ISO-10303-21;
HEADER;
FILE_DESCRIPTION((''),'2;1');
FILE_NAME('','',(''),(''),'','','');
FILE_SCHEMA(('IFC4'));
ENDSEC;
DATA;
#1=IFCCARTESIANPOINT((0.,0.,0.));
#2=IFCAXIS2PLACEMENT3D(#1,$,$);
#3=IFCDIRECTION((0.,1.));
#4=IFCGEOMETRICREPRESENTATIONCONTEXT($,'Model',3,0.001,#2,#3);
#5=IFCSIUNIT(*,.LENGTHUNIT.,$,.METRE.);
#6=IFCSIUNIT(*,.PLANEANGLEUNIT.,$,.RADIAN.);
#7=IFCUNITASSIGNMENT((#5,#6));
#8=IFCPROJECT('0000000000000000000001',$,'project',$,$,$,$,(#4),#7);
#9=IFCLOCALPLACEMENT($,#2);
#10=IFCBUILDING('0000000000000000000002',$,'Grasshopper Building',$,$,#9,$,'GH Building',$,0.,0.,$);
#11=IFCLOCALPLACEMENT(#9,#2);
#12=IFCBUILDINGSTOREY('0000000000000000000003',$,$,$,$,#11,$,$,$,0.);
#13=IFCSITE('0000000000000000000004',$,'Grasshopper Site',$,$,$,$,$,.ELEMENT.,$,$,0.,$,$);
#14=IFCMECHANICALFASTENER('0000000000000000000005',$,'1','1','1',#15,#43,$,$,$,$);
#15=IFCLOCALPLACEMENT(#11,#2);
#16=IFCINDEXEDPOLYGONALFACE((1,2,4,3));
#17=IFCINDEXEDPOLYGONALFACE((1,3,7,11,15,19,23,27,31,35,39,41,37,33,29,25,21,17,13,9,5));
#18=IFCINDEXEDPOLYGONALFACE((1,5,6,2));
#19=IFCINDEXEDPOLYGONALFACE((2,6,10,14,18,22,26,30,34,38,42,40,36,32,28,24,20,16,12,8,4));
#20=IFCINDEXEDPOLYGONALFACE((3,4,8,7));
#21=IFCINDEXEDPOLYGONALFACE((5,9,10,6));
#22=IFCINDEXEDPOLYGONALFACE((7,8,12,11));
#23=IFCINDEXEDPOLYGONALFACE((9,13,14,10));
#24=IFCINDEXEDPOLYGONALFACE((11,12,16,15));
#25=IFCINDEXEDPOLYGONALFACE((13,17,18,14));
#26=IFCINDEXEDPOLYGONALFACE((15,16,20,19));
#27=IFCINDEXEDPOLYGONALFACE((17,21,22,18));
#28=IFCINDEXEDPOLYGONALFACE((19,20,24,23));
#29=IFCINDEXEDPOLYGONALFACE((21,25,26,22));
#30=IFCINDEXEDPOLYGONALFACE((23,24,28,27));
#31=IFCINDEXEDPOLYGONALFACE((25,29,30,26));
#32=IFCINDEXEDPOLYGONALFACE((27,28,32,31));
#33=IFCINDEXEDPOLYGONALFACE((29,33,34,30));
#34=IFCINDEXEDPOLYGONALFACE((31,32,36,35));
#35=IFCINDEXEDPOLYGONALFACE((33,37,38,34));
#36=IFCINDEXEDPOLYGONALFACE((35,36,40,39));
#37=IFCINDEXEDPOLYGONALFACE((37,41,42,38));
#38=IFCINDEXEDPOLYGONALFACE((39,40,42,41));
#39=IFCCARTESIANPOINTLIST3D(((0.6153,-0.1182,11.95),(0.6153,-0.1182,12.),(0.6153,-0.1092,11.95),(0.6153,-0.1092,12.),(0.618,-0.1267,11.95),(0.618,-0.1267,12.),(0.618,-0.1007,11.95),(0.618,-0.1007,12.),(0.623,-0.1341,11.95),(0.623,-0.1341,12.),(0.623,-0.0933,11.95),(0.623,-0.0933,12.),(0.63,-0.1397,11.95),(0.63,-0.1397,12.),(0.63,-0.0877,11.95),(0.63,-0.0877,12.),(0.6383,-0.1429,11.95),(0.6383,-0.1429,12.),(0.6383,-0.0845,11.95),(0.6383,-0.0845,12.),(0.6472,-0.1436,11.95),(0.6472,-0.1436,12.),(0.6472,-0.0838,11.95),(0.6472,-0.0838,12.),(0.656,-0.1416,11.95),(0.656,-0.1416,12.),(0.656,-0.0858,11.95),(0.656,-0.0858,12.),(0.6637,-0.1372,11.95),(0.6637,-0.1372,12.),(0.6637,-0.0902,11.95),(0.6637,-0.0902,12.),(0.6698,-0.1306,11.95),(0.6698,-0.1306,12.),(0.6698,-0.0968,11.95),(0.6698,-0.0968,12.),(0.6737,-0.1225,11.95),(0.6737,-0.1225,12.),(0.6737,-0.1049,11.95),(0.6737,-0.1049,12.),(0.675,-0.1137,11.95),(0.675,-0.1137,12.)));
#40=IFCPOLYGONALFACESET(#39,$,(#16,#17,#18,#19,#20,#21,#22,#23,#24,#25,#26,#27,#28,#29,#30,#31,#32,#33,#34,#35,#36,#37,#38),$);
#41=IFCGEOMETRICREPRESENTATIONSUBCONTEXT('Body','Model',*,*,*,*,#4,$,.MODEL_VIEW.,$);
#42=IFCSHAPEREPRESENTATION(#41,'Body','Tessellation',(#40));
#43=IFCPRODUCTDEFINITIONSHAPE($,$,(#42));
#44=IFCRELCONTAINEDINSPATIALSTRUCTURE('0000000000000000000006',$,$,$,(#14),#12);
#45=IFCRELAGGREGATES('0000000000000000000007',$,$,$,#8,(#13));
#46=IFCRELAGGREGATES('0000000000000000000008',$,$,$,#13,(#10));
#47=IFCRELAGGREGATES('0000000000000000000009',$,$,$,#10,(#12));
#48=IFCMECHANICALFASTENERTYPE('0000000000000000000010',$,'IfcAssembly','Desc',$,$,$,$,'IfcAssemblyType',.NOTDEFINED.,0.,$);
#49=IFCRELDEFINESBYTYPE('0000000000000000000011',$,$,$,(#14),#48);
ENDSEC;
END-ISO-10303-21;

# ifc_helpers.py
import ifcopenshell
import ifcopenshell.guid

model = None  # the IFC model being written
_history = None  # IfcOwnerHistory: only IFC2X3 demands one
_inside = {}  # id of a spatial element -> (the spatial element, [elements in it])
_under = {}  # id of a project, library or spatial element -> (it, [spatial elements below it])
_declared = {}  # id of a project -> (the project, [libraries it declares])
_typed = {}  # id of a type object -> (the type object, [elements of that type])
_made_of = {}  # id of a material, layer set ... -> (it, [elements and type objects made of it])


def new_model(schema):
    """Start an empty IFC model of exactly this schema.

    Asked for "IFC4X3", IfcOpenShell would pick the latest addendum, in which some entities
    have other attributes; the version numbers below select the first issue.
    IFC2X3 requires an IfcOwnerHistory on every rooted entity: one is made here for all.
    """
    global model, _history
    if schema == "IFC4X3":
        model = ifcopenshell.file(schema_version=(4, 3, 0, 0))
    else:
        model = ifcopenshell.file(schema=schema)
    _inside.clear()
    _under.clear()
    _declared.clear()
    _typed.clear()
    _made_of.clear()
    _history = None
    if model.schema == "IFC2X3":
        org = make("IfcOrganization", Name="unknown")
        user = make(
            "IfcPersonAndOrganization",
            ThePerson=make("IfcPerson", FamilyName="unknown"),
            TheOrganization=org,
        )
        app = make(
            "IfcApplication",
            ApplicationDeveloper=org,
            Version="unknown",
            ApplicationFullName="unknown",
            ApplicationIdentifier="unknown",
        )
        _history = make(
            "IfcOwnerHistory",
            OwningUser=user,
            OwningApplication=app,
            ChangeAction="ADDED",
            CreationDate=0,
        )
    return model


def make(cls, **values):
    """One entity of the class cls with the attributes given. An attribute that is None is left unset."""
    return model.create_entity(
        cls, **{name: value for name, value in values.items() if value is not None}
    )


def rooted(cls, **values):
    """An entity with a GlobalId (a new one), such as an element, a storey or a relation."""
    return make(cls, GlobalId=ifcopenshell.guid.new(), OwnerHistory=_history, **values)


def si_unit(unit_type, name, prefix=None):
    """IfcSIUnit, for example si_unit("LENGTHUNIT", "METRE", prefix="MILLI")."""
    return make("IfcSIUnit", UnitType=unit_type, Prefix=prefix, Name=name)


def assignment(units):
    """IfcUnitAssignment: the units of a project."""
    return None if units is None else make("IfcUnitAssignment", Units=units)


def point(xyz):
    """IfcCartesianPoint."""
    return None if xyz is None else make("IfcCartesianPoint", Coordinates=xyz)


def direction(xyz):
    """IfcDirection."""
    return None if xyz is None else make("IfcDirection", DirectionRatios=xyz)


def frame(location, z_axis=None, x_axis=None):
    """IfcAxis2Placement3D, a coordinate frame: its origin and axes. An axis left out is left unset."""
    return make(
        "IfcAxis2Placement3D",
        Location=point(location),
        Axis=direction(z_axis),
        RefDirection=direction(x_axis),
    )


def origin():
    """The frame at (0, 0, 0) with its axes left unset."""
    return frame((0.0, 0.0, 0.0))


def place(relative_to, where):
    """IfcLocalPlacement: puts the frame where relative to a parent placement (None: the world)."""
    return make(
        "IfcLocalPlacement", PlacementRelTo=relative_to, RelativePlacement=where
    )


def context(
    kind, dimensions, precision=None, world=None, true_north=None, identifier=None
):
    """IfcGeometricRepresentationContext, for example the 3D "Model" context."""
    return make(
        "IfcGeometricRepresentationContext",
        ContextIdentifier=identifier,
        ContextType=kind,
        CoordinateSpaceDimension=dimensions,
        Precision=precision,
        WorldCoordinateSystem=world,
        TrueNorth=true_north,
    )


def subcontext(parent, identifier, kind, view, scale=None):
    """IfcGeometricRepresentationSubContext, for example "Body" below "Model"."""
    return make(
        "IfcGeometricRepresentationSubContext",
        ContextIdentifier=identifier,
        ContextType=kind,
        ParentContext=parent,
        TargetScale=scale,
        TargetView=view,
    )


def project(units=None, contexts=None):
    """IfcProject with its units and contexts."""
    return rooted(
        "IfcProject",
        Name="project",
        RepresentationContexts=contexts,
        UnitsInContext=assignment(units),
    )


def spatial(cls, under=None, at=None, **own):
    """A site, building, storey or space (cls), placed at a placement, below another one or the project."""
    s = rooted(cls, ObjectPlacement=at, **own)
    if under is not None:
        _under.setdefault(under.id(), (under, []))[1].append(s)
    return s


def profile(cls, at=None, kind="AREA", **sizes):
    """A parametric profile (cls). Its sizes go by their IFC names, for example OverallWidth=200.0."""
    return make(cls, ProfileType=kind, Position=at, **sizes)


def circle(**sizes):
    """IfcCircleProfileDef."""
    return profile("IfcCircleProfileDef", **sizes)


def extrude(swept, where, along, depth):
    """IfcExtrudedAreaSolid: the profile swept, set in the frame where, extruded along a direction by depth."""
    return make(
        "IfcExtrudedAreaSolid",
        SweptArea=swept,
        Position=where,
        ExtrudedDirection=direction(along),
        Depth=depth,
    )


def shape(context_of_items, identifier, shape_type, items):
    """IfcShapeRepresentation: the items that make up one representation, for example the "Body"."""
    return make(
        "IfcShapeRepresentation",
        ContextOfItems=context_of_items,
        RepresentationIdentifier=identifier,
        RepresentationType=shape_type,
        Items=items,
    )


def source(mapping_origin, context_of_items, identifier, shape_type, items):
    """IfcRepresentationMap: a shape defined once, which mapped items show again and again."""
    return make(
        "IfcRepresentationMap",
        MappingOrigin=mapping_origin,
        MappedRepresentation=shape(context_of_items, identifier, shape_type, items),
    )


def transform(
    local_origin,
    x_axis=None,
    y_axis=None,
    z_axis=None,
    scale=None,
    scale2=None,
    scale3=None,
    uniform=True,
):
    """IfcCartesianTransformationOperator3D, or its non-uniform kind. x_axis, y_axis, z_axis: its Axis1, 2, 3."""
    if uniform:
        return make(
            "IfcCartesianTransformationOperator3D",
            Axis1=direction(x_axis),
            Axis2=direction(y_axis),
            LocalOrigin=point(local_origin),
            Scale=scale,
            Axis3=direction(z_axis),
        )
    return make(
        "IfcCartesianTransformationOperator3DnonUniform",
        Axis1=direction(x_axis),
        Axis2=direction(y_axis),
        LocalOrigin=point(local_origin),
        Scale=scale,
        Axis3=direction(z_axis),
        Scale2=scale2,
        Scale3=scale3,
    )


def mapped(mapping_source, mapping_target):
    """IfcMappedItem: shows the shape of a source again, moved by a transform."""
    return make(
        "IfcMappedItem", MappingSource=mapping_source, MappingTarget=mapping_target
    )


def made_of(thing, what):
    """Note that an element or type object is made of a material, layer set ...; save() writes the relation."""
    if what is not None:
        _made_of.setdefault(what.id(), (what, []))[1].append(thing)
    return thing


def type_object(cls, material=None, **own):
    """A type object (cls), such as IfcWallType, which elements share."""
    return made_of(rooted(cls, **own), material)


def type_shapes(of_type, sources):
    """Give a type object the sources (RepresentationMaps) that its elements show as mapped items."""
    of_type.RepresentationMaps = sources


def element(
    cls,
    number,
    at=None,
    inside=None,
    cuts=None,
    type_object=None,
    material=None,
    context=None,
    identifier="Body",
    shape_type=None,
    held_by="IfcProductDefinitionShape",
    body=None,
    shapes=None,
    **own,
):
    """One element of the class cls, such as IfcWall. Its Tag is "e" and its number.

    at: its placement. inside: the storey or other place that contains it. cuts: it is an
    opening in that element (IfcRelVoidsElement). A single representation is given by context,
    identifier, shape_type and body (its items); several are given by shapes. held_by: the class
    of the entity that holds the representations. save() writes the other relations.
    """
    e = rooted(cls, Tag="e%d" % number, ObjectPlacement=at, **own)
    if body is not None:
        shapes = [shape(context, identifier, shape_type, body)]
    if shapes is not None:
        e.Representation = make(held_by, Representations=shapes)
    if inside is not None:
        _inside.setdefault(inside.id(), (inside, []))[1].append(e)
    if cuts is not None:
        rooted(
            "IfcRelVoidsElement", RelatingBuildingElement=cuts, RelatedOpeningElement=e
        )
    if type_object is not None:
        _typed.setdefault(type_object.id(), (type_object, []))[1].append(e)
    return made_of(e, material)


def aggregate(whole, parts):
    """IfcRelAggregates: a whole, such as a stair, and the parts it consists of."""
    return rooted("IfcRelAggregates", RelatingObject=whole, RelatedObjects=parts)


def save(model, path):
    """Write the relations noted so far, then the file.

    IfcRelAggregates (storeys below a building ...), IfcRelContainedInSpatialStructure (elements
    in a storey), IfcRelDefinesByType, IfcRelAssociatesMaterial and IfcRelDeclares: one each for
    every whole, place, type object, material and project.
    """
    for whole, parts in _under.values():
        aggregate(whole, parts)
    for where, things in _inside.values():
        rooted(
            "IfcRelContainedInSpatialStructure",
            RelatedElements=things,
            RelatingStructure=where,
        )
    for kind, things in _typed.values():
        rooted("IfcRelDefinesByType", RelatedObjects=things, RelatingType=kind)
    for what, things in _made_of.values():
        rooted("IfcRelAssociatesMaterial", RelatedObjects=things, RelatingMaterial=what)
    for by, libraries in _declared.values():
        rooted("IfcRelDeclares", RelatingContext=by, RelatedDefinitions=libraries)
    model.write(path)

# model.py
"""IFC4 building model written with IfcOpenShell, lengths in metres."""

from ifc_helpers import new_model, si_unit, direction, frame, origin, place, context, subcontext, project, spatial, circle, extrude, source, transform, mapped, type_object, type_shapes, element, save


model = new_model("IFC4")

# Units and contexts
model_context = context("Model", 3, precision=0.001, world=origin(), true_north=direction((0.0, 1.0)))
body_context = subcontext(model_context, "Body", "Model", "MODEL_VIEW")
ifc_project = project(units=[si_unit("LENGTHUNIT", "METRE"), si_unit("PLANEANGLEUNIT", "RADIAN")], contexts=[model_context])

# Site, building, storey
site = spatial("IfcSite", under=ifc_project, Name="Grasshopper Site", CompositionType="ELEMENT", RefElevation=0.0)
building_placement = place(None, origin())
building = spatial("IfcBuilding", under=site, at=building_placement, Name="Grasshopper Building", LongName="GH Building", ElevationOfRefHeight=0.0, ElevationOfTerrain=0.0)
storey_placement = place(building_placement, origin())
storey = spatial("IfcBuildingStorey", under=building, at=storey_placement, Elevation=0.0)

# Mechanical fastener
mechanical_fastener_type_1 = type_object("IfcMechanicalFastenerType", Name="IfcAssembly", Description="Desc", ElementType="IfcAssemblyType", NominalDiameter=0.0)
shared_shape_1 = source(origin(), body_context, "Body", "SweptSolid", [
    extrude(circle(Radius=0.03), frame((0.645, -0.1137, 12.0), z_axis=(0.0, 0.0, -1.0), x_axis=(1.0, 0.0, 0.0)), (0.0, 0.0, 1.0), 0.05),
])
type_shapes(mechanical_fastener_type_1, [shared_shape_1])
mechanical_fastener_1_placement = place(storey_placement, origin())
element("IfcMechanicalFastener", 1, at=mechanical_fastener_1_placement, inside=storey, type_object=mechanical_fastener_type_1, Name="1", Description="1", ObjectType="1", context=body_context, shape_type="MappedRepresentation", body=[
    mapped(shared_shape_1, transform((0.0, 0.0, 0.0), scale=1.0)),
])

save(model, "model.ifc")
